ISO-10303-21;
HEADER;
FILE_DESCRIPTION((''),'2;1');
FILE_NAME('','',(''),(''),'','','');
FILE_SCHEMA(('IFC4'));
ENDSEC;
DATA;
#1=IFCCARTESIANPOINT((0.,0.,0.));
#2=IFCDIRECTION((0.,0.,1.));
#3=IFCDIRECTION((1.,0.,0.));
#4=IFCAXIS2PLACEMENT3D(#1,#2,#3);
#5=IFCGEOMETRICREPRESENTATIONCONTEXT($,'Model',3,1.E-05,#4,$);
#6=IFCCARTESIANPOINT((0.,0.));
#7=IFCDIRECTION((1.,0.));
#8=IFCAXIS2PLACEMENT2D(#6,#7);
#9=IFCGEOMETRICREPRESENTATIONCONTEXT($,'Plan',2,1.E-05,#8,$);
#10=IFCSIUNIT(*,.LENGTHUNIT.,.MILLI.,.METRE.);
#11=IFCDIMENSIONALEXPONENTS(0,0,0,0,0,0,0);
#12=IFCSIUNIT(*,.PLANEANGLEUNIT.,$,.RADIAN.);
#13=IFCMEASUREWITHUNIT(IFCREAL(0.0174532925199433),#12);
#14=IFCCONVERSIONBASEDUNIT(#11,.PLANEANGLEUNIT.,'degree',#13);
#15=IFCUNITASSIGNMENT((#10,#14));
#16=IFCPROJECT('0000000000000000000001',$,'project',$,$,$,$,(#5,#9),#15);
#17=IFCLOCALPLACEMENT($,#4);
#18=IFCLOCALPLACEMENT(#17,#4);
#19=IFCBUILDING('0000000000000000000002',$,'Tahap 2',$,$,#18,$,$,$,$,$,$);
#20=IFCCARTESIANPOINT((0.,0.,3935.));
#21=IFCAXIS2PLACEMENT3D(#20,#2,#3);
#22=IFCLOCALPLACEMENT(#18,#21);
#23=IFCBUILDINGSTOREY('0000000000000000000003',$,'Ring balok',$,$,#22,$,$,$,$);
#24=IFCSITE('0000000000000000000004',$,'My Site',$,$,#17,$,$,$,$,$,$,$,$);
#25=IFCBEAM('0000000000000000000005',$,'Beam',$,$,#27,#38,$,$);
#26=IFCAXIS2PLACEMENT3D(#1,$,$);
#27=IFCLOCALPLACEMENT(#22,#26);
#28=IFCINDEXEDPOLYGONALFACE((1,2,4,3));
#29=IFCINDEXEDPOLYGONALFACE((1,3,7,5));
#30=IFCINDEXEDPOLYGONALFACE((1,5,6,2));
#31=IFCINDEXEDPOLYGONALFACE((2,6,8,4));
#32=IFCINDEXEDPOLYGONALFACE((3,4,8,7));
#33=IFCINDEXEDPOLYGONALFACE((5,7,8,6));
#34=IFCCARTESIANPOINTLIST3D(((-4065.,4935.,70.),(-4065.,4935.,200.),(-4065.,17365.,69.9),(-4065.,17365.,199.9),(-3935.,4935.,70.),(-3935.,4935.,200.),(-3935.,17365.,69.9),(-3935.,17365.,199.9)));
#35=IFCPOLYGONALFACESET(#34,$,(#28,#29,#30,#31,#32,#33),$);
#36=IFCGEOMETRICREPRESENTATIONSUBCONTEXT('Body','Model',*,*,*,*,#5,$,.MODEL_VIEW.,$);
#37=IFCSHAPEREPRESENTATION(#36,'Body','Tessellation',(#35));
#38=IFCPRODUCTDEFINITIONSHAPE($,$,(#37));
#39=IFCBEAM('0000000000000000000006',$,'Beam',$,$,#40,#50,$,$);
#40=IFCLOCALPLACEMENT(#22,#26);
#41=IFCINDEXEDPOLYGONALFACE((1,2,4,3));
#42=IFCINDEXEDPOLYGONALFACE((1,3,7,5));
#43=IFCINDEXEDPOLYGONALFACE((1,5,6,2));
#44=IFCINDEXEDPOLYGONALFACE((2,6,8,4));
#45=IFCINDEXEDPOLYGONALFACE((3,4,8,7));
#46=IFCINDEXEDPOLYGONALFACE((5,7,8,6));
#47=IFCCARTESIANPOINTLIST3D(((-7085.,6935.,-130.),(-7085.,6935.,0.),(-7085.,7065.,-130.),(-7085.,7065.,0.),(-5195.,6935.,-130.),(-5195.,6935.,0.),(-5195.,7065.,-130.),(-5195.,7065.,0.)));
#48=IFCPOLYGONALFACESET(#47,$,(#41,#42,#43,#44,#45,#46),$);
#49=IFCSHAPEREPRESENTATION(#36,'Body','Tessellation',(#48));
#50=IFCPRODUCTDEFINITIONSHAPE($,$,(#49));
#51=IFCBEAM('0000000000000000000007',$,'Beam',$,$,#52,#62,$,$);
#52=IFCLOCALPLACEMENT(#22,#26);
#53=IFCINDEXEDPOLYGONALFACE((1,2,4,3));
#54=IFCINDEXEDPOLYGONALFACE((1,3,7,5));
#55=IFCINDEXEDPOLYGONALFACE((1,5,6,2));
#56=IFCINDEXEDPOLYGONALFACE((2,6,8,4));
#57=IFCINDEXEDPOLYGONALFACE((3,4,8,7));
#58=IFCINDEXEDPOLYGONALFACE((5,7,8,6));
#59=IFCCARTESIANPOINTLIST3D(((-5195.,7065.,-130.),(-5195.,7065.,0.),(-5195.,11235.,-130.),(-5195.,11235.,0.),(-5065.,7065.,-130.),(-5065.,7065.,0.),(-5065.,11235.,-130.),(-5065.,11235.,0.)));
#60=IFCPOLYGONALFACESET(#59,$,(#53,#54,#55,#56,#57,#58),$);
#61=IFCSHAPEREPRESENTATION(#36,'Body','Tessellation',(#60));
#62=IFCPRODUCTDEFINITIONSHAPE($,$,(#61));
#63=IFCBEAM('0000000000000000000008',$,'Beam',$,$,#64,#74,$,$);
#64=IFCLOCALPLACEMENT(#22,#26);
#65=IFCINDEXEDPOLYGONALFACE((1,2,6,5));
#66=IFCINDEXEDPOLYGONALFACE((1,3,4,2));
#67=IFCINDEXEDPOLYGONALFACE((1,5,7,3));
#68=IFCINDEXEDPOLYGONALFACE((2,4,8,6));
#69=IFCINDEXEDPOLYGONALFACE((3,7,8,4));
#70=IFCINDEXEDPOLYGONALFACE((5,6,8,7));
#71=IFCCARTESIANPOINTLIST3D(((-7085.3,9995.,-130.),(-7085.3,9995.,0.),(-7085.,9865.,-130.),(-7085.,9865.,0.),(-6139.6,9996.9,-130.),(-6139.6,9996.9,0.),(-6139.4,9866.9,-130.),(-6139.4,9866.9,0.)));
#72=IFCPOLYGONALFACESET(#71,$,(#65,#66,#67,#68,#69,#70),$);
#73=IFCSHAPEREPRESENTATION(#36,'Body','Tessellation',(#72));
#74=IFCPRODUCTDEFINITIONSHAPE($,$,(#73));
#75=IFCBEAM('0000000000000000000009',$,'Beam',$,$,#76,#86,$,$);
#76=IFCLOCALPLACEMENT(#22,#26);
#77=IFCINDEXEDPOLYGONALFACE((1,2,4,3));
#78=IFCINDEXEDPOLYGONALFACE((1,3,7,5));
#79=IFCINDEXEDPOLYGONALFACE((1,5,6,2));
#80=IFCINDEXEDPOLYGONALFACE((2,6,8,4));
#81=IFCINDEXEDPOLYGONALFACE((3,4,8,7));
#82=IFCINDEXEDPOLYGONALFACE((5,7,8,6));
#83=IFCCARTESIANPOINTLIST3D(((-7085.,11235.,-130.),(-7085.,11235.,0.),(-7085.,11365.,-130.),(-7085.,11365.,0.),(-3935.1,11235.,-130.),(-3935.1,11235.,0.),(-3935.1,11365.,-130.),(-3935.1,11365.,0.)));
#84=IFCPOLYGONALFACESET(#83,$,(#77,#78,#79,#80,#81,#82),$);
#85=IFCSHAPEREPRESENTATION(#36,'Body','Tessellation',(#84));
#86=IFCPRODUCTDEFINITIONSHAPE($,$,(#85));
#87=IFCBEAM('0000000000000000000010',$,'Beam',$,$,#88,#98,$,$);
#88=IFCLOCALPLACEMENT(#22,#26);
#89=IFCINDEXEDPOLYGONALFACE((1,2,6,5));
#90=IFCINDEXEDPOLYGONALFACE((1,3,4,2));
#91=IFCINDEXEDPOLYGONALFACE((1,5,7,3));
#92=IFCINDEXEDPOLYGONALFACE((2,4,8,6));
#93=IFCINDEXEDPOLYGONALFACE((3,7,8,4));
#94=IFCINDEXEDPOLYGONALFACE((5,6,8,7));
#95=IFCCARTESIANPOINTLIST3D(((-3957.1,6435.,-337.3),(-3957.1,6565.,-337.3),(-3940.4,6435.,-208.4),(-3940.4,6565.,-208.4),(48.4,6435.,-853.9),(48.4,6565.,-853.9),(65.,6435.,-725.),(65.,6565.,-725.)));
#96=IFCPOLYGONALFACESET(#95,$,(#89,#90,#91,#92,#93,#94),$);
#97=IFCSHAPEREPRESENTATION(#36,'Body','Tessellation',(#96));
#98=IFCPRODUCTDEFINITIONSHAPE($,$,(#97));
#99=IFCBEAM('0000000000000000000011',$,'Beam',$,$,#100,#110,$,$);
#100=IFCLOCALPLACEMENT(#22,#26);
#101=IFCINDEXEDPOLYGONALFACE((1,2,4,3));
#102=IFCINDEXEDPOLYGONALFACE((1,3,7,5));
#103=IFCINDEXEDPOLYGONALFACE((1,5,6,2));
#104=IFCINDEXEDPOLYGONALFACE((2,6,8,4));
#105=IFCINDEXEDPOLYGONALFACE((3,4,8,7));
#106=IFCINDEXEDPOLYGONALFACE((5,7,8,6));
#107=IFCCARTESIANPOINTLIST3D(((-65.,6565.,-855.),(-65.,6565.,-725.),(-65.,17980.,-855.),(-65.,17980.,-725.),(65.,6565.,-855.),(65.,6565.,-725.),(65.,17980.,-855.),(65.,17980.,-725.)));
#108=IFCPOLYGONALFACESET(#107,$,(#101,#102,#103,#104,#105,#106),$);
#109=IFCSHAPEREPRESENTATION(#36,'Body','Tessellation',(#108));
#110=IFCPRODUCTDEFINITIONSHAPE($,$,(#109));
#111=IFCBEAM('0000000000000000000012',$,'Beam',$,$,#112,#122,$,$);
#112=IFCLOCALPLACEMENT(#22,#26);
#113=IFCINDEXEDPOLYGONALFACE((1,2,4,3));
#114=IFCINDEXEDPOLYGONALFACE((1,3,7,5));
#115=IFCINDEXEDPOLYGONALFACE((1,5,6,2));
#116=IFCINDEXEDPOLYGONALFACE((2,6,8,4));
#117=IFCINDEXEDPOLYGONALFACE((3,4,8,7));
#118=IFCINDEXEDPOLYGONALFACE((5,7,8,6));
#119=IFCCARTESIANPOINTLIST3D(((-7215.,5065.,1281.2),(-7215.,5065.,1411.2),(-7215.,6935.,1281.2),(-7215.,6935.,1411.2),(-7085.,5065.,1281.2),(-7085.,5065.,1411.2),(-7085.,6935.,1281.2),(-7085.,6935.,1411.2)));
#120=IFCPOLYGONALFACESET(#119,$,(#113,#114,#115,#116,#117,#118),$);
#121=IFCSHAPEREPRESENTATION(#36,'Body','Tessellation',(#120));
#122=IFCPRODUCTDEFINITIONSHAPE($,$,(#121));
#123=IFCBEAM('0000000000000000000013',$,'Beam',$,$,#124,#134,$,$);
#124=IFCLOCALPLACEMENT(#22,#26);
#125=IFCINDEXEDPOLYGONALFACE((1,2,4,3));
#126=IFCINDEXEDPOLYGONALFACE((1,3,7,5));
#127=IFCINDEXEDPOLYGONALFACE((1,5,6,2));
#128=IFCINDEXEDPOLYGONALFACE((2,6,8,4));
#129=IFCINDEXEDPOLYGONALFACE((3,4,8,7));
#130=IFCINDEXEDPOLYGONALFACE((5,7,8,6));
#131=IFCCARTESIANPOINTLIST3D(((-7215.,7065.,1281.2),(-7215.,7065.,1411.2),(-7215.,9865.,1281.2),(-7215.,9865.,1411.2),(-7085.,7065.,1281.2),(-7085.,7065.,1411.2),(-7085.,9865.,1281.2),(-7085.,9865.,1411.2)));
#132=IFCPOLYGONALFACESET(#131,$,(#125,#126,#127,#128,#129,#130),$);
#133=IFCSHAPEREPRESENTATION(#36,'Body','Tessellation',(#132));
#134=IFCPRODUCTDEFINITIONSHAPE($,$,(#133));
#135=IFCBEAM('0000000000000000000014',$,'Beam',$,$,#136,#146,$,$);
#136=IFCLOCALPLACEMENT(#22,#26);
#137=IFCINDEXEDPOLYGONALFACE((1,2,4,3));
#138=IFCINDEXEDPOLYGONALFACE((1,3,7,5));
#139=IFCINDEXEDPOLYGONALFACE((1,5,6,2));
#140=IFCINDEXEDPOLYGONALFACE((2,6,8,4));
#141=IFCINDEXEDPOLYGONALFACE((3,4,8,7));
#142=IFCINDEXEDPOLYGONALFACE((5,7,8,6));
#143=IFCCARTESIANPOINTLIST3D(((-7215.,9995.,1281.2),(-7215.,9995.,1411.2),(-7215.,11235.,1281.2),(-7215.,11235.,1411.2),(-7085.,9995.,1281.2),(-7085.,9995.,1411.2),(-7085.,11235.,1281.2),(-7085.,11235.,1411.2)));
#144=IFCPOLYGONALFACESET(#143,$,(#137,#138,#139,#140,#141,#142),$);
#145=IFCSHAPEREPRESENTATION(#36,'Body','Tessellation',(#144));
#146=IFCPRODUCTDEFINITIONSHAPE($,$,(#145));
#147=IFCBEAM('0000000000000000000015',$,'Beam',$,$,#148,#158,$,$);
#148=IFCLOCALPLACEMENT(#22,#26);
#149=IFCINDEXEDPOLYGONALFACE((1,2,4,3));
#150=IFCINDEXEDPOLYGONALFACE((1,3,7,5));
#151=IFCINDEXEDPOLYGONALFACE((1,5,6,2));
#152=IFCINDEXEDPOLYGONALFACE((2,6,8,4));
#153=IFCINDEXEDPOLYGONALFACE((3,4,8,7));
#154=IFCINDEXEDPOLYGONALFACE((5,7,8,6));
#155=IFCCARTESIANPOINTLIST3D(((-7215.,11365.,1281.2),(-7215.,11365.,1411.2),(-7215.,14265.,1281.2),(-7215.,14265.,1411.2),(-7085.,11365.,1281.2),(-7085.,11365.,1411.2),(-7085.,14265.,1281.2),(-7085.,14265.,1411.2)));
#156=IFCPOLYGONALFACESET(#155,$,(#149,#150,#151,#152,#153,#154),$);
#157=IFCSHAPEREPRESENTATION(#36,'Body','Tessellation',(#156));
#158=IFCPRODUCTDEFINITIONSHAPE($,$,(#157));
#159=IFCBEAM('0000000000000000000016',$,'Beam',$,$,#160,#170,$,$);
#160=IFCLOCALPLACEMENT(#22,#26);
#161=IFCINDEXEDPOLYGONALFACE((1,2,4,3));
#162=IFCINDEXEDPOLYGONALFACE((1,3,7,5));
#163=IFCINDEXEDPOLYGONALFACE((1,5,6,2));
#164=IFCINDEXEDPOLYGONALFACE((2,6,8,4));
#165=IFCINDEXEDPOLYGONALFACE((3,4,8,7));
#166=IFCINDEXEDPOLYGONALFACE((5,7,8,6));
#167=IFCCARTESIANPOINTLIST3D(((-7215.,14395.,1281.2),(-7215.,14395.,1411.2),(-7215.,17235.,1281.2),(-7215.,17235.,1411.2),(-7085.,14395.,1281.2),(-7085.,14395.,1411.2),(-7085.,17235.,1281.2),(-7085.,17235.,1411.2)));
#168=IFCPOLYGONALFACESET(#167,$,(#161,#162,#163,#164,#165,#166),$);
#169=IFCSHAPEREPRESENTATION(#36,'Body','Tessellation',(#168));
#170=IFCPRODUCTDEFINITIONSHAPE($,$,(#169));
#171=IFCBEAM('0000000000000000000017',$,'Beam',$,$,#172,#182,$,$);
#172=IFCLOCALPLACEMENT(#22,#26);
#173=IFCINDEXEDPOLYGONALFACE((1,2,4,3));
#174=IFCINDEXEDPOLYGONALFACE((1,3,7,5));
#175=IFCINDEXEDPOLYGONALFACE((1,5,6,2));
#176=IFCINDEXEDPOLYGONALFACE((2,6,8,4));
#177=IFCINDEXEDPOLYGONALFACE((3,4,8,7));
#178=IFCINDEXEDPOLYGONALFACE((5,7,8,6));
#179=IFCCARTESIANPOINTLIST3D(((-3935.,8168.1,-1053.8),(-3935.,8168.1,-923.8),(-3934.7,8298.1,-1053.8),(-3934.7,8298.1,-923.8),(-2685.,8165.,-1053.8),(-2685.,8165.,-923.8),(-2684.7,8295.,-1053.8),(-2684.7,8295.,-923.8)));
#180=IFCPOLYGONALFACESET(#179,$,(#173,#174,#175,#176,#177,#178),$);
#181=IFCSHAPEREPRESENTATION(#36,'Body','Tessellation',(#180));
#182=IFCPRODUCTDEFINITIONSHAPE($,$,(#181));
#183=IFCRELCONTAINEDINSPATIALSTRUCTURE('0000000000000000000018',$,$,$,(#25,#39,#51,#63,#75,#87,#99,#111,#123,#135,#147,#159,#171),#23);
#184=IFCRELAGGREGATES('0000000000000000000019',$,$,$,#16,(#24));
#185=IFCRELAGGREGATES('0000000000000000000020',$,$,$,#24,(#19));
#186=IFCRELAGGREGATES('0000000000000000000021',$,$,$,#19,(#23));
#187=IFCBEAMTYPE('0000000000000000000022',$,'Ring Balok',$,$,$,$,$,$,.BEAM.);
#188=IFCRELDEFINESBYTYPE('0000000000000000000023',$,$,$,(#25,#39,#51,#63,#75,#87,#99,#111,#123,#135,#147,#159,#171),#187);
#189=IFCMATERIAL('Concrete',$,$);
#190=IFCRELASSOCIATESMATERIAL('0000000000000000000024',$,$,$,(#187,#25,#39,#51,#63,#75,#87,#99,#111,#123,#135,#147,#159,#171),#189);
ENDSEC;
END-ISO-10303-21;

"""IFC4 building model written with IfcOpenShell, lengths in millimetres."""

from ifc_helpers import new_model, entity, si_unit, converted_unit, frame, origin_with_axes, origin_2d_with_axis, place, context, subcontext, project, spatial, rectangle, extrude, material, material_profile, profile_set, profile_usage, type_object, element, save


model = new_model("IFC4")

# Units and contexts
model_context = context("Model", 3, precision=1e-05, world=origin_with_axes())
plan_context = context("Plan", 2, precision=1e-05, world=origin_2d_with_axis())
body_context = subcontext(model_context, "Body", "Model", "MODEL_VIEW")
ifc_project = project(units=[si_unit("LENGTHUNIT", "METRE", prefix="MILLI"), converted_unit("PLANEANGLEUNIT", "degree", entity("IfcReal", 0.0174532925199433), si_unit("PLANEANGLEUNIT", "RADIAN"), dimensions=[0, 0, 0, 0, 0, 0, 0])], contexts=[model_context, plan_context])

# Site, building, storey
site_placement = place(None, origin_with_axes())
site = spatial("IfcSite", under=ifc_project, at=site_placement, Name="My Site")
building_placement = place(site_placement, origin_with_axes())
building = spatial("IfcBuilding", under=site, at=building_placement, Name="Tahap 2")
storey_placement = place(building_placement, frame((0.0, 0.0, 3935.0), z_axis=(0.0, 0.0, 1.0), x_axis=(1.0, 0.0, 0.0)))
storey = spatial("IfcBuildingStorey", under=building, at=storey_placement, Name="Ring balok")

# Beams
ifc_material = material(Name="Concrete")
ifc_material_profile_1 = material_profile(ifc_material, rectangle(XDim=130.0, YDim=130.0))
ifc_profile_set_1 = profile_set([ifc_material_profile_1])
ifc_profile_usage_1 = profile_usage(ifc_profile_set_1, cardinal=9)
beam_type_1 = type_object("IfcBeamType", Name="Ring Balok", PredefinedType="BEAM", material=ifc_profile_set_1)
beam_1_placement = place(storey_placement, frame((-3935.0, 4935.0, 200.0), z_axis=(0.0, 1.0, 0.0), x_axis=(-1.0, 0.0, 0.0)))
element("IfcBeam", 1, at=beam_1_placement, inside=storey, type_object=beam_type_1, material=ifc_profile_usage_1, Name="Beam", context=body_context, shape_type="SweptSolid", body=[
    extrude(rectangle(XDim=130.0, YDim=130.0), frame((65.0, -65.0, 0.0), z_axis=(0.0, 0.0, 1.0), x_axis=(1.0, 0.0, 0.0)), (0.0, 0.0, 1.0), 12430.0),
])
ifc_profile_usage_2 = profile_usage(ifc_profile_set_1, cardinal=9)
beam_2_placement = place(storey_placement, frame((-7085.0, 6935.0, 0.0), z_axis=(1.0, -0.000001, 0.0), x_axis=(0.000001, 1.0, 0.0)))
element("IfcBeam", 2, at=beam_2_placement, inside=storey, type_object=beam_type_1, material=ifc_profile_usage_2, Name="Beam", context=body_context, shape_type="SweptSolid", body=[
    extrude(rectangle(XDim=130.0, YDim=130.0), frame((65.0, -65.0, 0.0), z_axis=(0.0, 0.0, 1.0), x_axis=(1.0, 0.0, 0.0)), (0.0, 0.0, 1.0), 1890.0),
])
ifc_profile_usage_3 = profile_usage(ifc_profile_set_1, cardinal=9)
beam_3_placement = place(storey_placement, frame((-5065.0, 7065.0, 0.0), z_axis=(0.0, 1.0, 0.0), x_axis=(-1.0, 0.0, 0.0)))
element("IfcBeam", 3, at=beam_3_placement, inside=storey, type_object=beam_type_1, material=ifc_profile_usage_3, Name="Beam", context=body_context, shape_type="SweptSolid", body=[
    extrude(rectangle(XDim=130.0, YDim=130.0), frame((65.0, -65.0, 0.0), z_axis=(0.0, 0.0, 1.0), x_axis=(1.0, 0.0, 0.0)), (0.0, 0.0, 1.0), 4170.0),
])
ifc_profile_usage_4 = profile_usage(ifc_profile_set_1, cardinal=9)
beam_4_placement = place(storey_placement, frame((-7085.0, 9865.0, 0.0), z_axis=(0.999998, 0.001994, 0.000002), x_axis=(-0.001994, 0.999998, 0.0)))
element("IfcBeam", 4, at=beam_4_placement, inside=storey, type_object=beam_type_1, material=ifc_profile_usage_4, Name="Beam", context=body_context, shape_type="SweptSolid", body=[
    extrude(rectangle(XDim=130.0, YDim=130.0), frame((65.0, -65.0, 0.0), z_axis=(0.0, 0.0, 1.0), x_axis=(1.0, 0.0, 0.0)), (0.0, 0.0, 1.0), 945.6),
])
ifc_profile_usage_5 = profile_usage(ifc_profile_set_1, cardinal=9)
beam_5_placement = place(storey_placement, frame((-7085.0, 11235.0, 0.0), z_axis=(1.0, 0.0, 0.0), x_axis=(0.0, 1.0, 0.0)))
element("IfcBeam", 5, at=beam_5_placement, inside=storey, type_object=beam_type_1, material=ifc_profile_usage_5, Name="Beam", context=body_context, shape_type="SweptSolid", body=[
    extrude(rectangle(XDim=130.0, YDim=130.0), frame((65.0, -65.0, 0.0), z_axis=(0.0, 0.0, 1.0), x_axis=(1.0, 0.0, 0.0)), (0.0, 0.0, 1.0), 3149.9),
])
ifc_profile_usage_6 = profile_usage(ifc_profile_set_1, cardinal=7)
beam_6_placement = place(storey_placement, frame((65.0, 6435.0, -725.0), z_axis=(-0.991785, 0.000001, 0.127912), x_axis=(-0.000001, -1.0, 0.0)))
element("IfcBeam", 6, at=beam_6_placement, inside=storey, type_object=beam_type_1, material=ifc_profile_usage_6, Name="Beam", context=body_context, shape_type="SweptSolid", body=[
    extrude(rectangle(XDim=130.0, YDim=130.0), frame((-65.0, -65.0, 0.0), z_axis=(0.0, 0.0, 1.0), x_axis=(1.0, 0.0, 0.0)), (0.0, 0.0, 1.0), 4038.6),
])
ifc_profile_usage_7 = profile_usage(ifc_profile_set_1, cardinal=9)
beam_7_placement = place(storey_placement, frame((65.0, 6565.0, -725.0), z_axis=(0.0, 1.0, 0.0), x_axis=(-1.0, 0.0, 0.0)))
element("IfcBeam", 7, at=beam_7_placement, inside=storey, type_object=beam_type_1, material=ifc_profile_usage_7, Name="Beam", context=body_context, shape_type="SweptSolid", body=[
    extrude(rectangle(XDim=130.0, YDim=130.0), frame((65.0, -65.0, 0.0), z_axis=(0.0, 0.0, 1.0), x_axis=(1.0, 0.0, 0.0)), (0.0, 0.0, 1.0), 11415.0),
])
ifc_profile_usage_8 = profile_usage(ifc_profile_set_1, cardinal=9)
beam_8_placement = place(storey_placement, frame((-7085.0, 5065.0, 1411.2), z_axis=(0.0, 1.0, 0.0), x_axis=(-1.0, 0.0, 0.0)))
element("IfcBeam", 8, at=beam_8_placement, inside=storey, type_object=beam_type_1, material=ifc_profile_usage_8, Name="Beam", context=body_context, shape_type="SweptSolid", body=[
    extrude(rectangle(XDim=130.0, YDim=130.0), frame((65.0, -65.0, 0.0), z_axis=(0.0, 0.0, 1.0), x_axis=(1.0, 0.0, 0.0)), (0.0, 0.0, 1.0), 1870.0),
])
ifc_profile_usage_9 = profile_usage(ifc_profile_set_1, cardinal=9)
beam_9_placement = place(storey_placement, frame((-7085.0, 7065.0, 1411.2), z_axis=(0.0, 1.0, 0.0), x_axis=(-1.0, 0.0, 0.0)))
element("IfcBeam", 9, at=beam_9_placement, inside=storey, type_object=beam_type_1, material=ifc_profile_usage_9, Name="Beam", context=body_context, shape_type="SweptSolid", body=[
    extrude(rectangle(XDim=130.0, YDim=130.0), frame((65.0, -65.0, 0.0), z_axis=(0.0, 0.0, 1.0), x_axis=(1.0, 0.0, 0.0)), (0.0, 0.0, 1.0), 2800.0),
])
ifc_profile_usage_10 = profile_usage(ifc_profile_set_1, cardinal=9)
beam_10_placement = place(storey_placement, frame((-7085.0, 9995.0, 1411.2), z_axis=(0.000002, 1.0, 0.0), x_axis=(-1.0, 0.000002, 0.0)))
element("IfcBeam", 10, at=beam_10_placement, inside=storey, type_object=beam_type_1, material=ifc_profile_usage_10, Name="Beam", context=body_context, shape_type="SweptSolid", body=[
    extrude(rectangle(XDim=130.0, YDim=130.0), frame((65.0, -65.0, 0.0), z_axis=(0.0, 0.0, 1.0), x_axis=(1.0, 0.0, 0.0)), (0.0, 0.0, 1.0), 1240.0),
])
ifc_profile_usage_11 = profile_usage(ifc_profile_set_1, cardinal=9)
beam_11_placement = place(storey_placement, frame((-7085.0, 11365.0, 1411.2), z_axis=(0.0, 1.0, 0.0), x_axis=(-1.0, 0.0, 0.0)))
element("IfcBeam", 11, at=beam_11_placement, inside=storey, type_object=beam_type_1, material=ifc_profile_usage_11, Name="Beam", context=body_context, shape_type="SweptSolid", body=[
    extrude(rectangle(XDim=130.0, YDim=130.0), frame((65.0, -65.0, 0.0), z_axis=(0.0, 0.0, 1.0), x_axis=(1.0, 0.0, 0.0)), (0.0, 0.0, 1.0), 2900.0),
])
ifc_profile_usage_12 = profile_usage(ifc_profile_set_1, cardinal=9)
beam_12_placement = place(storey_placement, frame((-7085.0, 14395.0, 1411.2), z_axis=(0.000001, 1.0, 0.0), x_axis=(-1.0, 0.000001, 0.0)))
element("IfcBeam", 12, at=beam_12_placement, inside=storey, type_object=beam_type_1, material=ifc_profile_usage_12, Name="Beam", context=body_context, shape_type="SweptSolid", body=[
    extrude(rectangle(XDim=130.0, YDim=130.0), frame((65.0, -65.0, 0.0), z_axis=(0.0, 0.0, 1.0), x_axis=(1.0, 0.0, 0.0)), (0.0, 0.0, 1.0), 2840.0),
])
ifc_profile_usage_13 = profile_usage(ifc_profile_set_1, cardinal=9)
beam_13_placement = place(storey_placement, frame((-3935.0, 8168.1, -923.8), z_axis=(0.999997, -0.002443, 0.0), x_axis=(0.002443, 0.999997, 0.0)))
element("IfcBeam", 13, at=beam_13_placement, inside=storey, type_object=beam_type_1, material=ifc_profile_usage_13, Name="Beam", context=body_context, shape_type="SweptSolid", body=[
    extrude(rectangle(XDim=130.0, YDim=130.0), frame((65.0, -65.0, 0.0), z_axis=(0.0, 0.0, 1.0), x_axis=(1.0, 0.0, 0.0)), (0.0, 0.0, 1.0), 1250.0),
])

save(model, "model.ifc")
